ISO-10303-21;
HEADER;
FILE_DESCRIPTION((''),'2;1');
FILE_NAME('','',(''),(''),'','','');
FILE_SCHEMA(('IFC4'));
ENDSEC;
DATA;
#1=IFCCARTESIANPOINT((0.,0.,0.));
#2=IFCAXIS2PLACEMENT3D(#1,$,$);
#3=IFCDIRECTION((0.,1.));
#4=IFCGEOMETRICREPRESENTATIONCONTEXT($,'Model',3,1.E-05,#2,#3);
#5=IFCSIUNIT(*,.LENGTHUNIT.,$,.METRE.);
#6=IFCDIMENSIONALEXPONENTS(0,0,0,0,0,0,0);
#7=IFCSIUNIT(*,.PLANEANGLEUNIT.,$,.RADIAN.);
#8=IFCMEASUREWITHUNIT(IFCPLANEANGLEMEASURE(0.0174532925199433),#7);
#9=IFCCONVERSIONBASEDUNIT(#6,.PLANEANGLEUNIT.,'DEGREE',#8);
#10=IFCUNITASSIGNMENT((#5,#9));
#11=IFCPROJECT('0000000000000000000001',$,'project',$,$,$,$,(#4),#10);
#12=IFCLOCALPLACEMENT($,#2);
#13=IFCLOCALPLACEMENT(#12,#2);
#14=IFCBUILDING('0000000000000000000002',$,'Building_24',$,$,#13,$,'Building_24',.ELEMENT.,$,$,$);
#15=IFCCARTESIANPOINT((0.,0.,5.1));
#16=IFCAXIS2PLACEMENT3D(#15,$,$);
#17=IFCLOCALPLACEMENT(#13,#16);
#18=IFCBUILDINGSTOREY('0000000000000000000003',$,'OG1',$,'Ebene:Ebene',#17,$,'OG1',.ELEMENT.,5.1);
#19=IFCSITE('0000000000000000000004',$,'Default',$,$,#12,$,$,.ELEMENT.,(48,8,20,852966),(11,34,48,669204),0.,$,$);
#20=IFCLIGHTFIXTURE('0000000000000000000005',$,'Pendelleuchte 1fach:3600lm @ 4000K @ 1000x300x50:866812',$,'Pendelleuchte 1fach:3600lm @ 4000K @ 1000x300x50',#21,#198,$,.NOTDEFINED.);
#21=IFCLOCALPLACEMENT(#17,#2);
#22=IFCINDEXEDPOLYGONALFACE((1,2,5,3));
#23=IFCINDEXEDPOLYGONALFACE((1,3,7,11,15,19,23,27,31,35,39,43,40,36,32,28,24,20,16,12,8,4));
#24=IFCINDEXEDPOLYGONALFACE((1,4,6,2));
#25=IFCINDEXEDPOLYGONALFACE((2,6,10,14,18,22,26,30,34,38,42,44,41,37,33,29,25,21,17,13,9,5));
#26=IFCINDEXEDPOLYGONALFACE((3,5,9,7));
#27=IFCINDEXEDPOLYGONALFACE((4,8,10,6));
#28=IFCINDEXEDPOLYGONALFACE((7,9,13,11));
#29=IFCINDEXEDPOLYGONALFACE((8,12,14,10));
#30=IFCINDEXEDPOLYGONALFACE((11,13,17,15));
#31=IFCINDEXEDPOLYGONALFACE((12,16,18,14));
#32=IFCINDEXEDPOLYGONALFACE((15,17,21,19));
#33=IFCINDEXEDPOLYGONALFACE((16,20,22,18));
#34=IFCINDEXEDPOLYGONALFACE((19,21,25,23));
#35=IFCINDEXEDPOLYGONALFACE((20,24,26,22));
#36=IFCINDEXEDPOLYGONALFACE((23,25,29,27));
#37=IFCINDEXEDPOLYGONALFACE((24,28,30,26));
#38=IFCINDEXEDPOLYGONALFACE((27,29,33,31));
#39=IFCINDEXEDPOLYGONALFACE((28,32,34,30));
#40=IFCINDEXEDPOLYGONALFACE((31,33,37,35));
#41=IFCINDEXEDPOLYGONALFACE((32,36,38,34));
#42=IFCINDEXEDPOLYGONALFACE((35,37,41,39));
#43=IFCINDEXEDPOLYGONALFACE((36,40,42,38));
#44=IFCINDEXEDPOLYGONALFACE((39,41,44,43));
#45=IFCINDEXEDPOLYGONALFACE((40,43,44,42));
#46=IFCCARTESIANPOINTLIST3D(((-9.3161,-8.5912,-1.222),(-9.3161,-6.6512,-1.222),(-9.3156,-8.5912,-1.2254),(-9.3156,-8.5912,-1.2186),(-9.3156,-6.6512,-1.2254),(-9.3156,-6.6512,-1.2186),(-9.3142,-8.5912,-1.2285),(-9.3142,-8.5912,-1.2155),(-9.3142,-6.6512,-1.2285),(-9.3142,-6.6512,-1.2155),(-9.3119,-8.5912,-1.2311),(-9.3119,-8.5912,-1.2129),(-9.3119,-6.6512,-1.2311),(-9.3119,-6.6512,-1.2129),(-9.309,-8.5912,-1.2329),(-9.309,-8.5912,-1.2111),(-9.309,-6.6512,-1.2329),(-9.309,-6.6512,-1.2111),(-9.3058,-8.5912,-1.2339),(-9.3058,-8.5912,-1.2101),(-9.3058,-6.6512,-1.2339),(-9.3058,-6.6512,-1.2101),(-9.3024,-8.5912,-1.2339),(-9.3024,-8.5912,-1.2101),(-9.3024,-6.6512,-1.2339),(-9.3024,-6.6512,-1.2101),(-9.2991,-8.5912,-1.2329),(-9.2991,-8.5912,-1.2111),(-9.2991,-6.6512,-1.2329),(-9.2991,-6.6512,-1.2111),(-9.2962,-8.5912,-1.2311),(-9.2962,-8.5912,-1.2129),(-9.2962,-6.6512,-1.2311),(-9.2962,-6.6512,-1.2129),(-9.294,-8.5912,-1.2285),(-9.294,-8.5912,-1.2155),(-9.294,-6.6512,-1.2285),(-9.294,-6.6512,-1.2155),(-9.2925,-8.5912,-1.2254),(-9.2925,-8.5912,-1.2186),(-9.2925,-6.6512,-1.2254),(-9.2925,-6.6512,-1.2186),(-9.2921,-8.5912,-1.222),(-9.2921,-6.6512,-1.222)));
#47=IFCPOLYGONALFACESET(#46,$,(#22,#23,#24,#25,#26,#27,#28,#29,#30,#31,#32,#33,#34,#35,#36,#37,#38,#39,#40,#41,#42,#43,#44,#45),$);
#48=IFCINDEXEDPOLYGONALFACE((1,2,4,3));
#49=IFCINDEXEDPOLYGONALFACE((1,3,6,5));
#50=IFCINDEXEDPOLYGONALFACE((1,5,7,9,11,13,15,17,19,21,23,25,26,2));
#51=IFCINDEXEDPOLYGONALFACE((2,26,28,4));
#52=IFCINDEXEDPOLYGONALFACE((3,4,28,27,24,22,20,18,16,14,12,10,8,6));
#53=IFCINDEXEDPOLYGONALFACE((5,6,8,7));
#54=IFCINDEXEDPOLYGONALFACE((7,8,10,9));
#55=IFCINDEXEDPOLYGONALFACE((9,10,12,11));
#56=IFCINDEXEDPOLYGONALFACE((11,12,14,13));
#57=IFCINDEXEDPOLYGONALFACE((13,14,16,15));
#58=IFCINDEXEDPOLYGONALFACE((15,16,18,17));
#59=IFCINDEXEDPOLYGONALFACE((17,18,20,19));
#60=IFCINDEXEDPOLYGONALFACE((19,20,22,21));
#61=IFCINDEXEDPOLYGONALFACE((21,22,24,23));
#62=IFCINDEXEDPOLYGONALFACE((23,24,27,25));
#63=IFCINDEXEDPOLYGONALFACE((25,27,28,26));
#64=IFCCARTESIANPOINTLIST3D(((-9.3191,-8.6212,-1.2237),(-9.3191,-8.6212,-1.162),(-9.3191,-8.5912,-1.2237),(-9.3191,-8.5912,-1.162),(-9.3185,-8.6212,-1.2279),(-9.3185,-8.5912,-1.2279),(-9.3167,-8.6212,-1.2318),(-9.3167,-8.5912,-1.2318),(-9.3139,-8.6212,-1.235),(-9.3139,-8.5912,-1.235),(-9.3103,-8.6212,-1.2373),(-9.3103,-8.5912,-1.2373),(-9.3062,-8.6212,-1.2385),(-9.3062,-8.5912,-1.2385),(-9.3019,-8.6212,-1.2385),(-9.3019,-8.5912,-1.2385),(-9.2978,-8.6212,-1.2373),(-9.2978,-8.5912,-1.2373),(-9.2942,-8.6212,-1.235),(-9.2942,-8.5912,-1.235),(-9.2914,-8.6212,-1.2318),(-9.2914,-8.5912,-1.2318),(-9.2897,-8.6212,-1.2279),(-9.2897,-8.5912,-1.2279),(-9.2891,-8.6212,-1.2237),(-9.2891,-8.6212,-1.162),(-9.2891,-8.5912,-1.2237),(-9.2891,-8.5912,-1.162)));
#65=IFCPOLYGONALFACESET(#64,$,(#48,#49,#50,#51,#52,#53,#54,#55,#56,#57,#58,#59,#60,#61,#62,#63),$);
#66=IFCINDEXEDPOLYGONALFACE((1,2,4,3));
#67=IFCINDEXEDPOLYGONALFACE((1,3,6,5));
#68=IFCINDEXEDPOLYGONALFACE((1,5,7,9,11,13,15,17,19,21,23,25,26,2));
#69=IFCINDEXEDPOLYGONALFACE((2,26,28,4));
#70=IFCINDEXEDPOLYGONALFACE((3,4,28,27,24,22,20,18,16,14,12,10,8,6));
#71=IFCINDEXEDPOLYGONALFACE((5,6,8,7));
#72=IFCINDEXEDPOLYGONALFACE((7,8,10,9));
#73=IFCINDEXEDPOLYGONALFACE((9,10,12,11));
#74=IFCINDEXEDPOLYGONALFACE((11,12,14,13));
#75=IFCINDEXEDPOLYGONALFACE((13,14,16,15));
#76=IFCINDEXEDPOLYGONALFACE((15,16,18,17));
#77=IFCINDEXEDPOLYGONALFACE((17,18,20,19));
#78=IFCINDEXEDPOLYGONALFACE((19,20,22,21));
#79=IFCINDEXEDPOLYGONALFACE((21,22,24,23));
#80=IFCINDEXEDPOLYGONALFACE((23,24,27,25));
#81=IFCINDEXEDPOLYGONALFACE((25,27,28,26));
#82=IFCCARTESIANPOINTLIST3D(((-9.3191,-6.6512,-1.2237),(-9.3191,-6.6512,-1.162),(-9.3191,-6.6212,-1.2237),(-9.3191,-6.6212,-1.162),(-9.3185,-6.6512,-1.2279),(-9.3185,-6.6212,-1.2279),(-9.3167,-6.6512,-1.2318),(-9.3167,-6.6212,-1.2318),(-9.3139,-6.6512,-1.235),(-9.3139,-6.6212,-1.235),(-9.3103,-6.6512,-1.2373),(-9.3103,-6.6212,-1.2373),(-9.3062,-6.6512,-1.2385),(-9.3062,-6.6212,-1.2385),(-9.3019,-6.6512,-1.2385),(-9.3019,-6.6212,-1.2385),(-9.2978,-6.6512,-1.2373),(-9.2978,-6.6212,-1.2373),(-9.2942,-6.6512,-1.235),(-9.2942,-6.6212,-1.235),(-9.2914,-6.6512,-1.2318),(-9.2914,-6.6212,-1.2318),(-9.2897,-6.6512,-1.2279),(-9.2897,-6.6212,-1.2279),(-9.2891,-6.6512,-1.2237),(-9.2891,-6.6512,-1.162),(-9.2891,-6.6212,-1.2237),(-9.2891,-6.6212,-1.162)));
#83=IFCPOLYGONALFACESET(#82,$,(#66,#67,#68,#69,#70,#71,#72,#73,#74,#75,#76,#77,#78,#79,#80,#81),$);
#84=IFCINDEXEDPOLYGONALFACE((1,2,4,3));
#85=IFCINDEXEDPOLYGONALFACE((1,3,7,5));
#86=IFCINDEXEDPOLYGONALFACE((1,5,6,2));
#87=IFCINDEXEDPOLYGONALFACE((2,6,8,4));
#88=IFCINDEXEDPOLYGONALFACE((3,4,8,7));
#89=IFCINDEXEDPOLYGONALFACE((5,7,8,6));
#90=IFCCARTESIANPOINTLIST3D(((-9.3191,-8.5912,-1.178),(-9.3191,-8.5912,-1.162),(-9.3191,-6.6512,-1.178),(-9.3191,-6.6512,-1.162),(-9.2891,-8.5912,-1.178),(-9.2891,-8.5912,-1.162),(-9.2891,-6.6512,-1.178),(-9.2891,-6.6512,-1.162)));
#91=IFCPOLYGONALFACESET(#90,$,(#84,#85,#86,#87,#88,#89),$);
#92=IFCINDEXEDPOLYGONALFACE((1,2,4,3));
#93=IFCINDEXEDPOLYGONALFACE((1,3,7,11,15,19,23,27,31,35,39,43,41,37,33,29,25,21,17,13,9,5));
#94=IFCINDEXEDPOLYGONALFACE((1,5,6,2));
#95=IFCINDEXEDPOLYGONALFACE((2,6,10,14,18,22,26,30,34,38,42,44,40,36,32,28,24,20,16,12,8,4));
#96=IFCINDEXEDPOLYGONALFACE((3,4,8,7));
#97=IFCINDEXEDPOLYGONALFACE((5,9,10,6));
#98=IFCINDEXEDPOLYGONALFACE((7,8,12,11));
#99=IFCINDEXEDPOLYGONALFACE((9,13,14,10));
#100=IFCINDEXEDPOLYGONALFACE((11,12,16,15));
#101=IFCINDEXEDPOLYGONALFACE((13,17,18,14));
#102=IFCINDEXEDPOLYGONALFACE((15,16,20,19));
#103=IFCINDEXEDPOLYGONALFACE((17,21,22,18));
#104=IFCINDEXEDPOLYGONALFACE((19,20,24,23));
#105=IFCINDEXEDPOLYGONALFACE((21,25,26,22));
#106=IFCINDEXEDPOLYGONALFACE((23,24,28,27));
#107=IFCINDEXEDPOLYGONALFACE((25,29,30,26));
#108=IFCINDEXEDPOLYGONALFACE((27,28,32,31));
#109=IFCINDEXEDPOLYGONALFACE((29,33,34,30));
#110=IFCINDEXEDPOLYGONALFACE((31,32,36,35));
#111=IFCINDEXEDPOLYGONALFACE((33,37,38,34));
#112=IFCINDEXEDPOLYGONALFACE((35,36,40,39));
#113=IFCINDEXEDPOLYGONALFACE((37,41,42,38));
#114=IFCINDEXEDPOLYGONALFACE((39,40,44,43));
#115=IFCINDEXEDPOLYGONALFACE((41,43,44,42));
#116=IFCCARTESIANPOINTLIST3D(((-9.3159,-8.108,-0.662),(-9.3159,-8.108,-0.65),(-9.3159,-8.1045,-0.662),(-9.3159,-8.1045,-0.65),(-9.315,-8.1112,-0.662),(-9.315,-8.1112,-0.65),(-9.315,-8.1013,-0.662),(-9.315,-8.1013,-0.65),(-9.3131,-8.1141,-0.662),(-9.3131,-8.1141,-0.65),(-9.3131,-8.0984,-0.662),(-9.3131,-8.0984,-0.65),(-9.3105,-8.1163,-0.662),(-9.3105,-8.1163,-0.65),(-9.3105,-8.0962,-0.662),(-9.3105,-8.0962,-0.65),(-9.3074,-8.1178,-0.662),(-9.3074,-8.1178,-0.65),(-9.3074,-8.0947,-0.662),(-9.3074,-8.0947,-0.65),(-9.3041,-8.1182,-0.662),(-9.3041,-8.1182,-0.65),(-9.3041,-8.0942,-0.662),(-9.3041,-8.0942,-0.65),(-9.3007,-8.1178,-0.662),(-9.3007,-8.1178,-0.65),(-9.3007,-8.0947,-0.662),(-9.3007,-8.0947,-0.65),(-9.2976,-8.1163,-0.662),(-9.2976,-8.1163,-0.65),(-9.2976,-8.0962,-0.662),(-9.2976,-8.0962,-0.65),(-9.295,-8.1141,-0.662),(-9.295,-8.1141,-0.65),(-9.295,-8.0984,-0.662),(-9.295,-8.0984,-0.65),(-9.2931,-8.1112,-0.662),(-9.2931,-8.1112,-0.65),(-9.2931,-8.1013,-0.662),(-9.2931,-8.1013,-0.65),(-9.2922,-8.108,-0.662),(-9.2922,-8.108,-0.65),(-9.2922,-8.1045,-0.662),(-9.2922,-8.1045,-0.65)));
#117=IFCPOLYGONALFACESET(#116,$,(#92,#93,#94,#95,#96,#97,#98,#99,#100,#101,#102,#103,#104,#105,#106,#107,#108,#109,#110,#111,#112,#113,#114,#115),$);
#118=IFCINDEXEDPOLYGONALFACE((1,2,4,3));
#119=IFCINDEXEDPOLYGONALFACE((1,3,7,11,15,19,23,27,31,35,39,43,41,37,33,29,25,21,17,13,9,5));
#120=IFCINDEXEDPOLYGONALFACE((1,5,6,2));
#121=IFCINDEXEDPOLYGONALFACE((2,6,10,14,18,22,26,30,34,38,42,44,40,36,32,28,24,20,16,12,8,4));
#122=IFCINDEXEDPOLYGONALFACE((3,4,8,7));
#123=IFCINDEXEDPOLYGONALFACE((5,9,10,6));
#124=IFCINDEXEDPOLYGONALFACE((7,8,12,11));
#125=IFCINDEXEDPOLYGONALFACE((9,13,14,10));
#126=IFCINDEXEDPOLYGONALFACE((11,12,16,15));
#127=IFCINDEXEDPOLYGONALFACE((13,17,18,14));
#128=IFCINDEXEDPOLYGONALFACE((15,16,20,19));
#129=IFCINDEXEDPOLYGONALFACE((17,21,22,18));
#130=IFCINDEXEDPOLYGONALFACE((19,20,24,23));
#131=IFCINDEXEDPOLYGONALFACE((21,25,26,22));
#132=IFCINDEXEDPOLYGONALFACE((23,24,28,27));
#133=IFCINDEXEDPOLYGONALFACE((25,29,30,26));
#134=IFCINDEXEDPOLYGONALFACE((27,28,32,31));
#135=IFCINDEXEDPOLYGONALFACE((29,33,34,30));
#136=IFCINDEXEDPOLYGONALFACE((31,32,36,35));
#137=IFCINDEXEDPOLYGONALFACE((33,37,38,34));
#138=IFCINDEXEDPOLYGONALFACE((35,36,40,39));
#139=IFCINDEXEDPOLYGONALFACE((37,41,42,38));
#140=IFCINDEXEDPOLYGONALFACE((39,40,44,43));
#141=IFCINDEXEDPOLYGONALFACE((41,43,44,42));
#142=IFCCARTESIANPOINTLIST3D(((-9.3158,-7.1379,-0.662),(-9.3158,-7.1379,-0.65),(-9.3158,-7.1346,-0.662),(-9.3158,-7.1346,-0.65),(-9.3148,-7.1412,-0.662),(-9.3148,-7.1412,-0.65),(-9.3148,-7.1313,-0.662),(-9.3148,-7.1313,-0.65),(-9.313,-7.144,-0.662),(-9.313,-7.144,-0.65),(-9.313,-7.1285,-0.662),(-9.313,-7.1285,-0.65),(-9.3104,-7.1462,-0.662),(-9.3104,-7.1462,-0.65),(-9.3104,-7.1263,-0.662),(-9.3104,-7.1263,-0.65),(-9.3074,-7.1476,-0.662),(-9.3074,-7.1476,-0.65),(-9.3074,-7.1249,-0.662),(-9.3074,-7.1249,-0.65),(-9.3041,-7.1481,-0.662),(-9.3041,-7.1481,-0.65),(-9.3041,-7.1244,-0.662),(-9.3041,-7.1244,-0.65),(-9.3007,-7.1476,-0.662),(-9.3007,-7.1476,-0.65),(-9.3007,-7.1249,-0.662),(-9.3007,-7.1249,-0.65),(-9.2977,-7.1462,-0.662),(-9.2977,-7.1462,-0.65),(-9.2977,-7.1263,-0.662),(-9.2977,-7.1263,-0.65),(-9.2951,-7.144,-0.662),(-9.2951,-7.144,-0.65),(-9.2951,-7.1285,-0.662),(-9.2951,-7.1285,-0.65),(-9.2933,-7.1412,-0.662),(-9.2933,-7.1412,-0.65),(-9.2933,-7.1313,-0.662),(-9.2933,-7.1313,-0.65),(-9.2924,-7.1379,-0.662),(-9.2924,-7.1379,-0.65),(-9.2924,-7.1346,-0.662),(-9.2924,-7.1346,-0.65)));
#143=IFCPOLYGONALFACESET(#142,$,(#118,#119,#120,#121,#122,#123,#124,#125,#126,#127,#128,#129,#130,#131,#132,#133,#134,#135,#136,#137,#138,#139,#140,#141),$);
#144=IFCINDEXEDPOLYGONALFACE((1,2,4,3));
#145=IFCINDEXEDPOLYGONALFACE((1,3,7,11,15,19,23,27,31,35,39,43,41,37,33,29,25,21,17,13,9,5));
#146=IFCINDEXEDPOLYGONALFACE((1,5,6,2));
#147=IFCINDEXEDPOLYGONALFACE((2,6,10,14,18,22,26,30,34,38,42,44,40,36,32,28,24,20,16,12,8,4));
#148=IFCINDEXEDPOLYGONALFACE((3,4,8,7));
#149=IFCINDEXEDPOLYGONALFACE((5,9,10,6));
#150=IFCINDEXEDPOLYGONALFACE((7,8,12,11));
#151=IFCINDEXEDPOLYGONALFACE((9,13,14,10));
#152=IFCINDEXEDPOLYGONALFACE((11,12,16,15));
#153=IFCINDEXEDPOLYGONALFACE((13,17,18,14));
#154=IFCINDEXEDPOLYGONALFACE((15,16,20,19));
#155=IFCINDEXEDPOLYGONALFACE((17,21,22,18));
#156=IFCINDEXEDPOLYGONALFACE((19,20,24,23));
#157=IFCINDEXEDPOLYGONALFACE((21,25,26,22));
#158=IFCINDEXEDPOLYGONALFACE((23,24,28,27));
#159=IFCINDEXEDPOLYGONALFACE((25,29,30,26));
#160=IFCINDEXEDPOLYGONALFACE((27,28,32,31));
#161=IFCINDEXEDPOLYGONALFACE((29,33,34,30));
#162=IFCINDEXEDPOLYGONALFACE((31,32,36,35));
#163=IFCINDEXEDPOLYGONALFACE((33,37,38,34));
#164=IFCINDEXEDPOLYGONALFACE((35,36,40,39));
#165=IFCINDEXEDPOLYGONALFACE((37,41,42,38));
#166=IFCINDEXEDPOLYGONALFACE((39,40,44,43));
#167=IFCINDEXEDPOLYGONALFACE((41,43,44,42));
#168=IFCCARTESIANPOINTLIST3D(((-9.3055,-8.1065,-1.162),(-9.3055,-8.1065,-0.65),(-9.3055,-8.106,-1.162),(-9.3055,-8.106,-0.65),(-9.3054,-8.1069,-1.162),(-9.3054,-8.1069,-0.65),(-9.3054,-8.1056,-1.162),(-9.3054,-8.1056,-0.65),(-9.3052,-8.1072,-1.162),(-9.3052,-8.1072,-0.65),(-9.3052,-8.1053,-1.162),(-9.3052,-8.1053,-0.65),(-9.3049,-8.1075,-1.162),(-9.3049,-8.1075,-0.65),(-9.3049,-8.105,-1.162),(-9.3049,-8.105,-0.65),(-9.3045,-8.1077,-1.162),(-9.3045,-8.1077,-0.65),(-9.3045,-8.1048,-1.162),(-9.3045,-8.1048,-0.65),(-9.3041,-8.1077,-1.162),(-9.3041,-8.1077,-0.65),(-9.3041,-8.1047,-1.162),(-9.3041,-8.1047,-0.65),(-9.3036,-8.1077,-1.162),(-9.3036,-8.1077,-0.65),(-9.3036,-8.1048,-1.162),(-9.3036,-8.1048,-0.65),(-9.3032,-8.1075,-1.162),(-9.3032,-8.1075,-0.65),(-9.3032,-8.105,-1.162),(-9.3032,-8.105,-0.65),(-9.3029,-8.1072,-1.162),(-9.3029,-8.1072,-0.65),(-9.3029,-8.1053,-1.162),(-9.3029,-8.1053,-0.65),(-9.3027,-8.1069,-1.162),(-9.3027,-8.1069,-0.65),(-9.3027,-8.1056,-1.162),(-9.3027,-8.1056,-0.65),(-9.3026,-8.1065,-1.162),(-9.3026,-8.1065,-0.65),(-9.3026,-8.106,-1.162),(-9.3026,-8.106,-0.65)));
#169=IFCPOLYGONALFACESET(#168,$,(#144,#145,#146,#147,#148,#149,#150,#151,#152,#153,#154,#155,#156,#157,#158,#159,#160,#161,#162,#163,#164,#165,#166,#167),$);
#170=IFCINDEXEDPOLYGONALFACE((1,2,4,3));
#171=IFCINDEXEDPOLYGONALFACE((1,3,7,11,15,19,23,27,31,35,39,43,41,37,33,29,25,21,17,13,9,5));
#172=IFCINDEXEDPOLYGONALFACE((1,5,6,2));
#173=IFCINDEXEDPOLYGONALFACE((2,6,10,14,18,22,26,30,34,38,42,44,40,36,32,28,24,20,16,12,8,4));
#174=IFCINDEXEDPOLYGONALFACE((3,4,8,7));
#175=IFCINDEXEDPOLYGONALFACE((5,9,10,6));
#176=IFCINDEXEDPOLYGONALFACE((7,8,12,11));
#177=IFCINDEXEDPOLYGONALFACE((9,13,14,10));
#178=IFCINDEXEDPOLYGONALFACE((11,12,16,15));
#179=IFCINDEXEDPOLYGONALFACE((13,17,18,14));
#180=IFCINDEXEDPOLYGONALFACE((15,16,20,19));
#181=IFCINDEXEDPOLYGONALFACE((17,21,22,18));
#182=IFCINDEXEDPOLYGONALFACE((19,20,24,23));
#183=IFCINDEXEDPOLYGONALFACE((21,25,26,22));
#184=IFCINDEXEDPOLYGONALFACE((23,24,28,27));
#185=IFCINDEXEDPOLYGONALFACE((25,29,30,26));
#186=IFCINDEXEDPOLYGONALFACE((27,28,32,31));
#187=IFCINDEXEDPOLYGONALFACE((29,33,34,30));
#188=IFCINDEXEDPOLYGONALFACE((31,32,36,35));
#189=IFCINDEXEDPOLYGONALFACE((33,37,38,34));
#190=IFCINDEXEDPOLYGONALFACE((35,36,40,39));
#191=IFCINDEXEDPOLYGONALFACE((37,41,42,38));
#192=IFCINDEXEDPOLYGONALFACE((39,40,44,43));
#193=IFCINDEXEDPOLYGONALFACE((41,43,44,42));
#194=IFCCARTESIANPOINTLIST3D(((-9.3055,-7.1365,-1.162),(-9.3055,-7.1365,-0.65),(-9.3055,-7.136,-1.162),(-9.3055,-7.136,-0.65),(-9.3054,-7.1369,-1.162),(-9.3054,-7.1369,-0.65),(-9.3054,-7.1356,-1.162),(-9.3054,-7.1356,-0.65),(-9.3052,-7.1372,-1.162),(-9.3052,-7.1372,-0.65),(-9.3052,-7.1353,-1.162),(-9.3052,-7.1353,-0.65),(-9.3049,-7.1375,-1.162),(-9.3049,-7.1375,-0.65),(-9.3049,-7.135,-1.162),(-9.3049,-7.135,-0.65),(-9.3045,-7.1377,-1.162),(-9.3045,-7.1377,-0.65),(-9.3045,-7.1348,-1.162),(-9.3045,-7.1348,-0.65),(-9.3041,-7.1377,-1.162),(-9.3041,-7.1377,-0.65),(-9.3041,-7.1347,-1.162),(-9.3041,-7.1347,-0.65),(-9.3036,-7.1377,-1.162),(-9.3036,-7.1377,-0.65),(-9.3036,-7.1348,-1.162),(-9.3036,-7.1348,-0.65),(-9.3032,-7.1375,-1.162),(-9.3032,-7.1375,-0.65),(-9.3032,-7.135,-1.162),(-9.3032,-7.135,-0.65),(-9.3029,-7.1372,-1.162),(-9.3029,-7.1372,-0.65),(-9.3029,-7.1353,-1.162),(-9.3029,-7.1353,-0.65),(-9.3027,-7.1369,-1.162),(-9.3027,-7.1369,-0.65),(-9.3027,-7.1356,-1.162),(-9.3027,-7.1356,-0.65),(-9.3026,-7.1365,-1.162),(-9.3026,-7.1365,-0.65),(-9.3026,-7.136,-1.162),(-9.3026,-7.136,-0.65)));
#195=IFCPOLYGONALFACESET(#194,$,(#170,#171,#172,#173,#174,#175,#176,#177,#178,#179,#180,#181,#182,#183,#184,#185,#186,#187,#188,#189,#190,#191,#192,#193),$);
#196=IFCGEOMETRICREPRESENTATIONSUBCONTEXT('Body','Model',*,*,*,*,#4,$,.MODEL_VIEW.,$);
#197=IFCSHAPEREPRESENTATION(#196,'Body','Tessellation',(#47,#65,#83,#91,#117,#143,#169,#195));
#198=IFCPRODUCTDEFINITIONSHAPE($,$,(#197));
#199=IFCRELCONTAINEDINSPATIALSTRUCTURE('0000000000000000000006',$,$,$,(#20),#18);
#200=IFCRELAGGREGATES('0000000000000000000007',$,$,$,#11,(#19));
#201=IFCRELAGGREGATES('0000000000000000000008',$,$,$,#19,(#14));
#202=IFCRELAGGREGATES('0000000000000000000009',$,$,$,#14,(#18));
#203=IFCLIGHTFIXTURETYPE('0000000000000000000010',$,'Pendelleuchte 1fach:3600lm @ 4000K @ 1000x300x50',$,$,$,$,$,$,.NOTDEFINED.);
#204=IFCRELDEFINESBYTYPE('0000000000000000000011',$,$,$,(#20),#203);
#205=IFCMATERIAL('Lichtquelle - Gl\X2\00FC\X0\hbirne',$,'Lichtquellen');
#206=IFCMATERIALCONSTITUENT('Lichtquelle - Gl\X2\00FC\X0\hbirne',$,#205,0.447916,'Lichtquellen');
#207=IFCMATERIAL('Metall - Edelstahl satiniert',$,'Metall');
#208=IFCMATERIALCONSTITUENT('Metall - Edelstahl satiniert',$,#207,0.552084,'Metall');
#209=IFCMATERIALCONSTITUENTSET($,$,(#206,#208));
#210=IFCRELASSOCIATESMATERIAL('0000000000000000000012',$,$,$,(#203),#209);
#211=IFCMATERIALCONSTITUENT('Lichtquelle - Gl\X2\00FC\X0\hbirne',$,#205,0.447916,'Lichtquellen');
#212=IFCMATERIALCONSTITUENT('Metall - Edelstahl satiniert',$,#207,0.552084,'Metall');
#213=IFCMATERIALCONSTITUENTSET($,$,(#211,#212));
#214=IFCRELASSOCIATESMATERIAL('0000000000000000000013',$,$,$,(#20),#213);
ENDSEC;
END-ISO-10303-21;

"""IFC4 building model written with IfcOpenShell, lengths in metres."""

from ifc_helpers import new_model, entity, si_unit, converted_unit, direction, frame, origin, place, context, subcontext, project, spatial, line, arc, indexed_curve, outline, extrude, source, transform, mapped, material, constituent, constituent_set, type_object, type_shapes, element, save


model = new_model("IFC4")

# Units and contexts
model_context = context("Model", 3, precision=1e-05, world=origin(), true_north=direction((0.0, 1.0)))
body_context = subcontext(model_context, "Body", "Model", "MODEL_VIEW")
ifc_project = project(units=[si_unit("LENGTHUNIT", "METRE"), converted_unit("PLANEANGLEUNIT", "DEGREE", entity("IfcPlaneAngleMeasure", 0.0174532925199433), si_unit("PLANEANGLEUNIT", "RADIAN"), dimensions=[0, 0, 0, 0, 0, 0, 0])], contexts=[model_context])

# Site, building, storey
site_placement = place(None, origin())
site = spatial("IfcSite", under=ifc_project, at=site_placement, Name="Default", CompositionType="ELEMENT", RefLatitude=(48, 8, 20, 852966), RefLongitude=(11, 34, 48, 669204), RefElevation=0.0)
building_placement = place(site_placement, origin())
building = spatial("IfcBuilding", under=site, at=building_placement, Name="Building_24", LongName="Building_24", CompositionType="ELEMENT")
storey_placement = place(building_placement, frame((0.0, 0.0, 5.1)))
storey = spatial("IfcBuildingStorey", under=building, at=storey_placement, Name="OG1", ObjectType="Ebene:Ebene", LongName="OG1", CompositionType="ELEMENT", Elevation=5.1)

# Light fixture
ifc_material_1 = material(Name="Lichtquelle - Glühbirne", Category="Lichtquellen")
ifc_material_2 = material(Name="Metall - Edelstahl satiniert", Category="Metall")
ifc_constituent_1 = constituent(ifc_material_1, Name="Lichtquelle - Glühbirne", Category="Lichtquellen", fraction=0.447916)
ifc_constituent_2 = constituent(ifc_material_2, Name="Metall - Edelstahl satiniert", Category="Metall", fraction=0.552084)
ifc_constituent_set_1 = constituent_set(constituents=[ifc_constituent_1, ifc_constituent_2])
light_fixture_type_1 = type_object("IfcLightFixtureType", Name="Pendelleuchte 1fach:3600lm @ 4000K @ 1000x300x50", PredefinedType="NOTDEFINED", material=ifc_constituent_set_1)
shared_shape_1 = source(origin(), body_context, "Body", "SweptSolid", [
    extrude(outline(indexed_curve([(-0.012, 0.0), (0.0, -0.012), (0.012, 0.0), (0.0, 0.012)], segments=[arc(1, 2, 3), arc(3, 4, 1)], self_intersect=False)), frame((-0.97, 0.0, -0.572), z_axis=(1.0, 0.0, 0.0), x_axis=(0.0, 1.0, 0.0)), (0.0, 0.0, 1.0), 1.94),
    extrude(outline(indexed_curve([(-0.0308, -0.015), (0.0308, -0.015), (0.0308, 0.015), (-0.0308, 0.015), (-0.0458, 0.0)], segments=[line(1, 2, 3, 4), arc(4, 5, 1)], self_intersect=False)), frame((0.97, 0.0, -0.5428), z_axis=(1.0, 0.0, 0.0), x_axis=(0.0, 0.0, 1.0)), (0.0, 0.0, 1.0), 0.03),
    extrude(outline(indexed_curve([(-0.0308, -0.015), (0.0308, -0.015), (0.0308, 0.015), (-0.0308, 0.015), (-0.0458, 0.0)], segments=[line(1, 2, 3, 4), arc(4, 5, 1)], self_intersect=False)), frame((-1.0, 0.0, -0.5428), z_axis=(1.0, 0.0, 0.0), x_axis=(0.0, 0.0, 1.0)), (0.0, 0.0, 1.0), 0.03),
    extrude(outline(indexed_curve([(-0.97, -0.015), (0.97, -0.015), (0.97, 0.015), (-0.97, 0.015), (-0.97, -0.015)], self_intersect=False)), frame((0.0, 0.0, -0.528), z_axis=(0.0, 0.0, 1.0), x_axis=(-1.0, 0.0, 0.0)), (0.0, 0.0, 1.0), 0.016),
    extrude(outline(indexed_curve([(-0.012, 0.0), (0.0, -0.012), (0.012, 0.0), (0.0, 0.012)], segments=[arc(1, 2, 3), arc(3, 4, 1)], self_intersect=False)), frame((0.485, 0.0, -0.012)), (0.0, 0.0, 1.0), 0.012),
    extrude(outline(indexed_curve([(-0.0118, 0.0), (0.0, -0.0118), (0.0118, 0.0), (0.0, 0.0118)], segments=[arc(1, 2, 3), arc(3, 4, 1)], self_intersect=False)), frame((-0.485, 0.0, -0.012)), (0.0, 0.0, 1.0), 0.012),
    extrude(outline(indexed_curve([(-0.0015, 0.0), (0.0, -0.0015), (0.0015, 0.0), (0.0, 0.0015)], segments=[arc(1, 2, 3), arc(3, 4, 1)], self_intersect=False)), frame((0.485, 0.0, -0.512)), (0.0, 0.0, 1.0), 0.512),
    extrude(outline(indexed_curve([(-0.0015, 0.0), (0.0, -0.0015), (0.0015, 0.0), (0.0, 0.0015)], segments=[arc(1, 2, 3), arc(3, 4, 1)], self_intersect=False)), frame((-0.485, 0.0, -0.512)), (0.0, 0.0, 1.0), 0.512),
])
type_shapes(light_fixture_type_1, [shared_shape_1])
ifc_constituent_3 = constituent(ifc_material_1, Name="Lichtquelle - Glühbirne", Category="Lichtquellen", fraction=0.447916)
ifc_constituent_4 = constituent(ifc_material_2, Name="Metall - Edelstahl satiniert", Category="Metall", fraction=0.552084)
ifc_constituent_set_2 = constituent_set(constituents=[ifc_constituent_3, ifc_constituent_4])
light_fixture_1_placement = place(storey_placement, frame((-9.3041, -7.6212, -0.65), z_axis=(0.0, 0.0, 1.0), x_axis=(0.0, -1.0, 0.0)))
element("IfcLightFixture", 1, at=light_fixture_1_placement, inside=storey, type_object=light_fixture_type_1, material=ifc_constituent_set_2, Name="Pendelleuchte 1fach:3600lm @ 4000K @ 1000x300x50:866812", ObjectType="Pendelleuchte 1fach:3600lm @ 4000K @ 1000x300x50", PredefinedType="NOTDEFINED", context=body_context, shape_type="MappedRepresentation", body=[
    mapped(shared_shape_1, transform((0.0, 0.0, 0.0), scale=1.0)),
])

save(model, "model.ifc")
